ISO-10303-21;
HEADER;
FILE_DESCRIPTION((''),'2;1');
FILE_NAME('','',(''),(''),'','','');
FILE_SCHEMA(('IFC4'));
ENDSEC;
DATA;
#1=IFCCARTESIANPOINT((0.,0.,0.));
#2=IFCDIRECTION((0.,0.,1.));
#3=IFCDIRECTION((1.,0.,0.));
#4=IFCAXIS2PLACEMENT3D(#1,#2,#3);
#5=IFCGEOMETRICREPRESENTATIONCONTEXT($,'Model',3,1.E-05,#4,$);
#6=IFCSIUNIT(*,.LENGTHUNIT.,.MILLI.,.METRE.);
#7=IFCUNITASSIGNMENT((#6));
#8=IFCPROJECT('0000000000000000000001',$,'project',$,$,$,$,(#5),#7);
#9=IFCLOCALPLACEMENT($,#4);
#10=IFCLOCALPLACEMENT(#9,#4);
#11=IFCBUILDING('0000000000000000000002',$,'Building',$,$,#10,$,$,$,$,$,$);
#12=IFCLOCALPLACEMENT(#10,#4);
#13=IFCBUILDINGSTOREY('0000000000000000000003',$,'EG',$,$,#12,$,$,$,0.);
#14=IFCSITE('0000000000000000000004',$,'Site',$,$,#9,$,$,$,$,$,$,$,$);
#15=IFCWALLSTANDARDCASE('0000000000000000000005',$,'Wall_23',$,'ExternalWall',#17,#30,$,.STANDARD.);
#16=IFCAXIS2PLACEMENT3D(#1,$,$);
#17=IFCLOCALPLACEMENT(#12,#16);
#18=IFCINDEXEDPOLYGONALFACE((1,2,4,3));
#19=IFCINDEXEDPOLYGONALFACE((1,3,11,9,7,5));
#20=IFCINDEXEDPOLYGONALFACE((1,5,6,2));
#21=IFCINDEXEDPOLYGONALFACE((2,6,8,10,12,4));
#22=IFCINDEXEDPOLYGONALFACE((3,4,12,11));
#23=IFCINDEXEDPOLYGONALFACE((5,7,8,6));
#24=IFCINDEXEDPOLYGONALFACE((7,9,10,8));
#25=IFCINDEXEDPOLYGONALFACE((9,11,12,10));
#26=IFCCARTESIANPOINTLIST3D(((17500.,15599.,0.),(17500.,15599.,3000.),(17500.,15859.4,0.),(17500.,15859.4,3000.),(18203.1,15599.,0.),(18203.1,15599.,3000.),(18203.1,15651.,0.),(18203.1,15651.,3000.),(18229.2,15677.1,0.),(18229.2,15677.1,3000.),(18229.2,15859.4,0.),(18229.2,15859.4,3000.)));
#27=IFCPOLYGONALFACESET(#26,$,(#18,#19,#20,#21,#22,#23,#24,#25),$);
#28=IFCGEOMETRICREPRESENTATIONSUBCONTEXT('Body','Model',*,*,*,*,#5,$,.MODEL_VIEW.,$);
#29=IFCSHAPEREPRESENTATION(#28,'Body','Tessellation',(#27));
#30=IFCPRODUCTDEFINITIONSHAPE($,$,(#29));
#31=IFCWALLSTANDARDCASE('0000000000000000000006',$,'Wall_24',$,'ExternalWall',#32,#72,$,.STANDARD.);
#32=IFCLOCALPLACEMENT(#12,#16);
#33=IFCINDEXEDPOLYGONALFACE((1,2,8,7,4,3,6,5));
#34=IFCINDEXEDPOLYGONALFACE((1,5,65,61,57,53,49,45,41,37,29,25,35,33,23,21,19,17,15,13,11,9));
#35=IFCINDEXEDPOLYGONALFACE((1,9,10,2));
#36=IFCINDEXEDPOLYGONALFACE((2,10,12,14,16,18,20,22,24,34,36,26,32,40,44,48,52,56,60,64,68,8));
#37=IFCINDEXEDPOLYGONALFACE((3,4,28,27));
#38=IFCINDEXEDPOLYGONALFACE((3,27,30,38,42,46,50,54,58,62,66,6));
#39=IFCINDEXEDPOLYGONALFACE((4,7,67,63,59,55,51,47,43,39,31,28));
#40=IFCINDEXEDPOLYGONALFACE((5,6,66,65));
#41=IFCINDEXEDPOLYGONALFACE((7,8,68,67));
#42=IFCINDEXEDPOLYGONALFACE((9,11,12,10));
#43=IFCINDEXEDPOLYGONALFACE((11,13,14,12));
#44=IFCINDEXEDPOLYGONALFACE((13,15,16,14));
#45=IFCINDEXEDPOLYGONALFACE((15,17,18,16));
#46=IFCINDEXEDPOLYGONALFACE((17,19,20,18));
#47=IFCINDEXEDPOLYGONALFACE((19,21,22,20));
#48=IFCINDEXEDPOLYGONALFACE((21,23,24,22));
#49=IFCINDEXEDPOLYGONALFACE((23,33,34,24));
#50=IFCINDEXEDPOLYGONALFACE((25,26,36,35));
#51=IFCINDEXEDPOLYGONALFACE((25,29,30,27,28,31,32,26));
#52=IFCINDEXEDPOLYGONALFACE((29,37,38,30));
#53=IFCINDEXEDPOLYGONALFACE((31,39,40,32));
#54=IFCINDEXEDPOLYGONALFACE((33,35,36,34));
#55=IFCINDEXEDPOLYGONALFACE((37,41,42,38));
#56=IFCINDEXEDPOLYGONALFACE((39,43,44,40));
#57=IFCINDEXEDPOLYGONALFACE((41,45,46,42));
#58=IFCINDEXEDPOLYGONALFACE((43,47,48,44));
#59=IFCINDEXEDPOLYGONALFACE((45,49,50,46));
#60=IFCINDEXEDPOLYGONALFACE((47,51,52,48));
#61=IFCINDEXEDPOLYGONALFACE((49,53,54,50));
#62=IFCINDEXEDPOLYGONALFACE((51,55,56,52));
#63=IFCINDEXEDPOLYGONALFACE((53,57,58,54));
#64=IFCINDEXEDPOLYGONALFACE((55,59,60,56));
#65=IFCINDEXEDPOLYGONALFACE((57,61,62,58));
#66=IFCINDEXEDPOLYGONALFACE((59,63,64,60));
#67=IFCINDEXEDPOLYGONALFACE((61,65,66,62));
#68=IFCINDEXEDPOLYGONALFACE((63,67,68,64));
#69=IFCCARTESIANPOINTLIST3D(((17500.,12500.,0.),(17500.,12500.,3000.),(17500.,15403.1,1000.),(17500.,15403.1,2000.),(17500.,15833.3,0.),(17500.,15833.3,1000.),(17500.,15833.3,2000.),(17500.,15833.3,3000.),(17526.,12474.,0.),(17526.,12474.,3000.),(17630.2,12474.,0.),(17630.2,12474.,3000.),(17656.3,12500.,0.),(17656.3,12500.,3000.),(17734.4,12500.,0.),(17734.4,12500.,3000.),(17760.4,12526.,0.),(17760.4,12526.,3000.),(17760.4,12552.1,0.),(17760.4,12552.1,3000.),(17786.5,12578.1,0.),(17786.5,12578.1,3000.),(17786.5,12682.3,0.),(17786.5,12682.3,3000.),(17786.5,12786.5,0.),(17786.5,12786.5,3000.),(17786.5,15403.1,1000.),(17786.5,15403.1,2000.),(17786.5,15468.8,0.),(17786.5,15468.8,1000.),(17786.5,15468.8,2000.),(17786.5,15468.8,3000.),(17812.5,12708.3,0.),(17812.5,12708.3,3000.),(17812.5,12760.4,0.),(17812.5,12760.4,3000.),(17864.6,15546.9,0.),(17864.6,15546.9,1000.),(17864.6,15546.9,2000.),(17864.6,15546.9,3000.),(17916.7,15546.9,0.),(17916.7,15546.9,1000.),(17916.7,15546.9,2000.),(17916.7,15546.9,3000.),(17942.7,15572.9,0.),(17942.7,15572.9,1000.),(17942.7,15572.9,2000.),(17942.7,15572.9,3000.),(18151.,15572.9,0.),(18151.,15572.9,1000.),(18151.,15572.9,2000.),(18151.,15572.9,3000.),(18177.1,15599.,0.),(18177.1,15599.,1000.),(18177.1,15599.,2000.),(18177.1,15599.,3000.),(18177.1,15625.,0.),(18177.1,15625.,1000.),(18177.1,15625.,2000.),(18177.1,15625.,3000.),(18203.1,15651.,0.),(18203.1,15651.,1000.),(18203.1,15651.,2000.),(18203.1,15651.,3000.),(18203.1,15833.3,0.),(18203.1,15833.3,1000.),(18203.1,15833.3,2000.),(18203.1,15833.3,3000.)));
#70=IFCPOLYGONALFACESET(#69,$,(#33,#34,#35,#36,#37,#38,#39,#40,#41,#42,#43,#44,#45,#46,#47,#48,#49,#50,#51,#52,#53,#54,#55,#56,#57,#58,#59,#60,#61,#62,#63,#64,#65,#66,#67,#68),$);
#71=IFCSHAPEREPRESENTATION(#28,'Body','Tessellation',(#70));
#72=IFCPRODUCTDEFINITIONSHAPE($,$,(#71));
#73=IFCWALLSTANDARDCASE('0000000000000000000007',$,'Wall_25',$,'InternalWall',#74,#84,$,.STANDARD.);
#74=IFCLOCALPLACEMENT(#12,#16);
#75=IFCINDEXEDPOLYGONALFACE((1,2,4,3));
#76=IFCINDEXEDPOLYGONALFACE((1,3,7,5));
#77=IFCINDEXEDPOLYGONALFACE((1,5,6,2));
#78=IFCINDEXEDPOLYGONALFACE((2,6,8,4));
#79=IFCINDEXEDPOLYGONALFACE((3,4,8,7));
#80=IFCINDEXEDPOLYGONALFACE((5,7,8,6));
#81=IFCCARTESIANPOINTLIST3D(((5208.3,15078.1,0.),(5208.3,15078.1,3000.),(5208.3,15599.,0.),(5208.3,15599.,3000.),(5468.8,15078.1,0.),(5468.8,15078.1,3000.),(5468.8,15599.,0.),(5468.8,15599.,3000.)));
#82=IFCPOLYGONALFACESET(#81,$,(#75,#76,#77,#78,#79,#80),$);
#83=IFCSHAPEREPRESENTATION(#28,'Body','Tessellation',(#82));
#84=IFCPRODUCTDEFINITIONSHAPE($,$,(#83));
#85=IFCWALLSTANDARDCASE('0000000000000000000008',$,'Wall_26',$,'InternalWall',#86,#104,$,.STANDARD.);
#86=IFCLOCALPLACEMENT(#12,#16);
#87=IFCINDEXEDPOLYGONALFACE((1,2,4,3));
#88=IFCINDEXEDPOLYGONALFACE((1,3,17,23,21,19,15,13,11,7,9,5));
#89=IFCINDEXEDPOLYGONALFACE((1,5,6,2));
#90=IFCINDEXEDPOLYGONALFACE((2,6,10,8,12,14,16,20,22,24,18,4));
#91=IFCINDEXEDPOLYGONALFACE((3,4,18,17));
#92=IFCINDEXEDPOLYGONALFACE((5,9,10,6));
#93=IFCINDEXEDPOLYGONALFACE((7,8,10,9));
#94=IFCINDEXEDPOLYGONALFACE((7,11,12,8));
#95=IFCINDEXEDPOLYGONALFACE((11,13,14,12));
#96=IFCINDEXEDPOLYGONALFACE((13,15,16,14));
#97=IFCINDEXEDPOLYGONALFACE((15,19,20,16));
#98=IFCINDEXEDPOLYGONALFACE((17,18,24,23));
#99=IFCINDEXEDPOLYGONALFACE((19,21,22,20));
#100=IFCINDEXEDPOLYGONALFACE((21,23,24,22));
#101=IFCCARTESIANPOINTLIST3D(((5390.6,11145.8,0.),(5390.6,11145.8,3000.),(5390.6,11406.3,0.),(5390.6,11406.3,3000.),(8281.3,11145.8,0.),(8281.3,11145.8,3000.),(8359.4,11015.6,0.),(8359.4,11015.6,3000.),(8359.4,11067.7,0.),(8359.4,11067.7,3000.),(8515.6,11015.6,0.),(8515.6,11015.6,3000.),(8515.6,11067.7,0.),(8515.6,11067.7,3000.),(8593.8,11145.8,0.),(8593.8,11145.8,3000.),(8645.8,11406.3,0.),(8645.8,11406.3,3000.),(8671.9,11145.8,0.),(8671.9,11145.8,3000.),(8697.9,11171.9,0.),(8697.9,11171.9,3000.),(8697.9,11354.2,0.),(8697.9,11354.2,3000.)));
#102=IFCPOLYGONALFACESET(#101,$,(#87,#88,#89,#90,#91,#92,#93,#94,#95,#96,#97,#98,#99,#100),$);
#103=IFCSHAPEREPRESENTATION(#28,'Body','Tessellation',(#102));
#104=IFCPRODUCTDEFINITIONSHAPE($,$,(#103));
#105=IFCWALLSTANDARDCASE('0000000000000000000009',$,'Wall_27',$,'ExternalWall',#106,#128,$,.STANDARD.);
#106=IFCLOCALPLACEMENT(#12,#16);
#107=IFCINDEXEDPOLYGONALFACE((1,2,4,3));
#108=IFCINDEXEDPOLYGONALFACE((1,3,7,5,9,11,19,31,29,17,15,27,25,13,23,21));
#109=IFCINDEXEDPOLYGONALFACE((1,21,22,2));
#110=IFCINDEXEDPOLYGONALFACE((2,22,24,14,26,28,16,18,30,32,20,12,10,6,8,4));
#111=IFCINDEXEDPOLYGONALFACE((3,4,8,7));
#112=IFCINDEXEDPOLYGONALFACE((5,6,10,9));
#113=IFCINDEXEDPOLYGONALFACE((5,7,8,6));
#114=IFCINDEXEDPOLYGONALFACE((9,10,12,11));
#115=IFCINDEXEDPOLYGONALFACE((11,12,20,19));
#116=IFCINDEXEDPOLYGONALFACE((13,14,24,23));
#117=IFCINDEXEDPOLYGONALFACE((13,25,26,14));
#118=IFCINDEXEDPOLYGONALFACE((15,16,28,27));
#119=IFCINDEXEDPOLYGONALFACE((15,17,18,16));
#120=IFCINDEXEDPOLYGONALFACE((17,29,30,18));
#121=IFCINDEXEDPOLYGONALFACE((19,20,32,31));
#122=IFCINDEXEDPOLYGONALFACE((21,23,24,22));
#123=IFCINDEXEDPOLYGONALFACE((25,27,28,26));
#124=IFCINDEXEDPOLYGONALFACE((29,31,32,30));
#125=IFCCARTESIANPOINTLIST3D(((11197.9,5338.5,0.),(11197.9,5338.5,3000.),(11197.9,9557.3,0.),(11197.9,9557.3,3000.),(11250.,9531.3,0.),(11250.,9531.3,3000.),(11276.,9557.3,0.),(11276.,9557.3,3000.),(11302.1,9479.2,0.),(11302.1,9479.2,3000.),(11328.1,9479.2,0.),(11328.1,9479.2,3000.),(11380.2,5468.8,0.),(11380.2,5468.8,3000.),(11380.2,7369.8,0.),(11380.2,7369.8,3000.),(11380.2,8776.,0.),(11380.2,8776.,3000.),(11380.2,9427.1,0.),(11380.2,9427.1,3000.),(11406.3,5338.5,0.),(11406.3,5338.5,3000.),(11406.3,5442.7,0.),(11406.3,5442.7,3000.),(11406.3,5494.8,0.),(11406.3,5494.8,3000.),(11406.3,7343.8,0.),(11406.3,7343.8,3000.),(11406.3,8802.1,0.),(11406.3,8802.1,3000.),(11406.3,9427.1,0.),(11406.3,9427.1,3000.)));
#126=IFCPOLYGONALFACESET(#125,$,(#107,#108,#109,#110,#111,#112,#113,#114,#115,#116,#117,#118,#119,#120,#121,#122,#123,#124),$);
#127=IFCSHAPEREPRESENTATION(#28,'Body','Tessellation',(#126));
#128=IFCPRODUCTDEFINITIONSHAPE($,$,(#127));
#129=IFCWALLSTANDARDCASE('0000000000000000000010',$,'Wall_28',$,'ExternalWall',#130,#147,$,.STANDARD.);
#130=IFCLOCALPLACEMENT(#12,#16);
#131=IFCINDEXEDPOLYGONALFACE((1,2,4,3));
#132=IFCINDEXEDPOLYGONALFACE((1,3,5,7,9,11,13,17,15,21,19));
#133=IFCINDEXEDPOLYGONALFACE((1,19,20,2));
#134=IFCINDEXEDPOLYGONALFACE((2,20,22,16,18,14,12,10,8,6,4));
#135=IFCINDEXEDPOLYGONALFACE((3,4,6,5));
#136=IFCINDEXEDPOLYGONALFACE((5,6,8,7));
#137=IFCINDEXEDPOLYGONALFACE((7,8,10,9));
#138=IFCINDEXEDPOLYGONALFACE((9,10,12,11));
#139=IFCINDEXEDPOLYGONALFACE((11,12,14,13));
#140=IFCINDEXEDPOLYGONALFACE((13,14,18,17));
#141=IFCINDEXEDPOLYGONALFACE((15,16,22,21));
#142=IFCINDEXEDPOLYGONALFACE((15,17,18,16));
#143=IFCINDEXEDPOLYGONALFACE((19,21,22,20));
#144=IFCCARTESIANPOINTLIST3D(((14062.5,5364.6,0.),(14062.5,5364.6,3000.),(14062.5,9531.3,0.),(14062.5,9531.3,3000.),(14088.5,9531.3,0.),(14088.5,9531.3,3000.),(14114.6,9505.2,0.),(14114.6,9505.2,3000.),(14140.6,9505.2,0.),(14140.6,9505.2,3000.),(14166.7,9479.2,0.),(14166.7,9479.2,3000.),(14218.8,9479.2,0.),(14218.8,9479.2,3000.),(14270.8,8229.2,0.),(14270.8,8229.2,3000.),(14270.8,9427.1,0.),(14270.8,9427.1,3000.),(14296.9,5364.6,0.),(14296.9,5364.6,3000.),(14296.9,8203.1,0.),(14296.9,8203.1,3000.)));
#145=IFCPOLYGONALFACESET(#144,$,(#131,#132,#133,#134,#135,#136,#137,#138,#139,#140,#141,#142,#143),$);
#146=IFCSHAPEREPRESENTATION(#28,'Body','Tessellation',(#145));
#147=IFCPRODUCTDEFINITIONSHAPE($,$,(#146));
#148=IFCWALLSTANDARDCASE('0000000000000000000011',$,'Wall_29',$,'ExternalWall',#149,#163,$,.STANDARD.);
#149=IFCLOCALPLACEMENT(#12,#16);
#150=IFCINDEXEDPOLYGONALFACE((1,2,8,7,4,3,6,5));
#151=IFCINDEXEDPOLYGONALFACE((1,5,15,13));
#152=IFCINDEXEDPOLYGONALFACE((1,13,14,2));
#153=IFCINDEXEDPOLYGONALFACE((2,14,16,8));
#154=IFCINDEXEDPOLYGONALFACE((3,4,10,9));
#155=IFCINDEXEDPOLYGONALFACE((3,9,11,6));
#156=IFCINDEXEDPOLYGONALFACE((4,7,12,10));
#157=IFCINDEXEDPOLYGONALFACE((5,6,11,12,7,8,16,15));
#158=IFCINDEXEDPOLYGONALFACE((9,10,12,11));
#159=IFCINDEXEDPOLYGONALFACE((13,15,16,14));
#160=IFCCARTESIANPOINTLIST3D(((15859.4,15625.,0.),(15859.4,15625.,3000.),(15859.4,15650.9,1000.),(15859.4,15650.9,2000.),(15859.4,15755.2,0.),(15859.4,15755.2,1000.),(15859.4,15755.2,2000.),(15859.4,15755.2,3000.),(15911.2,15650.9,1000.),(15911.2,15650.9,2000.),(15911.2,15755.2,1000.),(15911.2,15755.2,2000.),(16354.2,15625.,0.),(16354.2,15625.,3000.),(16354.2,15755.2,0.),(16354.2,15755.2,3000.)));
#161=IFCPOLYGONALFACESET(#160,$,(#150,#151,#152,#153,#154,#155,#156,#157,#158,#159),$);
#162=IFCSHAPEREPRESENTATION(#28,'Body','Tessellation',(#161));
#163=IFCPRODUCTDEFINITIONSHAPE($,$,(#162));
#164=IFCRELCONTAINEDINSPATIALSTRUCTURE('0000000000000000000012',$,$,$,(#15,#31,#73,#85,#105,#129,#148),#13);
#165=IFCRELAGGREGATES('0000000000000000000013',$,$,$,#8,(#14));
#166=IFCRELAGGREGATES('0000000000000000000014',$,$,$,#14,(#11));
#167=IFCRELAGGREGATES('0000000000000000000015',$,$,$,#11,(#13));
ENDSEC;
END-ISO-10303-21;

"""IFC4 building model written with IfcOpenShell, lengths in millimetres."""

from ifc_helpers import new_model, si_unit, frame, origin_with_axes, place, context, subcontext, project, spatial, polyline, rectangle, outline, extrude, element, save


model = new_model("IFC4")

# Units and contexts
model_context = context("Model", 3, precision=1e-05, world=origin_with_axes())
body_context = subcontext(model_context, "Body", "Model", "MODEL_VIEW")
ifc_project = project(units=[si_unit("LENGTHUNIT", "METRE", prefix="MILLI")], contexts=[model_context])

# Site, building, storey
site_placement = place(None, origin_with_axes())
site = spatial("IfcSite", under=ifc_project, at=site_placement, Name="Site")
building_placement = place(site_placement, origin_with_axes())
building = spatial("IfcBuilding", under=site, at=building_placement, Name="Building")
storey_placement = place(building_placement, origin_with_axes())
storey = spatial("IfcBuildingStorey", under=building, at=storey_placement, Name="EG", Elevation=0.0)

# Wall
wall_1_placement = place(storey_placement, origin_with_axes())
element("IfcWallStandardCase", 1, at=wall_1_placement, inside=storey, Name="Wall_23", ObjectType="ExternalWall", PredefinedType="STANDARD", context=body_context, shape_type="SweptSolid", body=[
    extrude(outline(polyline([(17500.0, 15599.0, 0.0), (17500.0, 15859.4, 0.0), (18229.2, 15859.4, 0.0), (18229.2, 15677.1, 0.0), (18203.1, 15651.0, 0.0), (18203.1, 15599.0, 0.0), (17500.0, 15599.0, 0.0)])), origin_with_axes(), (0.0, 0.0, 1.0), 3000.0),
])

# Wall, opening
wall_2_placement = place(storey_placement, origin_with_axes())
wall_2 = element("IfcWallStandardCase", 2, at=wall_2_placement, inside=storey, Name="Wall_24", ObjectType="ExternalWall", PredefinedType="STANDARD", context=body_context, shape_type="SweptSolid", body=[
    extrude(outline(polyline([(17526.0, 12474.0, 0.0), (17500.0, 12500.0, 0.0), (17500.0, 15833.3, 0.0), (18203.1, 15833.3, 0.0), (18203.1, 15651.0, 0.0), (18177.1, 15625.0, 0.0), (18177.1, 15599.0, 0.0), (18151.0, 15572.9, 0.0), (17942.7, 15572.9, 0.0), (17916.7, 15546.9, 0.0), (17864.6, 15546.9, 0.0), (17786.5, 15468.8, 0.0), (17786.5, 12786.5, 0.0), (17812.5, 12760.4, 0.0), (17812.5, 12708.3, 0.0), (17786.5, 12682.3, 0.0), (17786.5, 12578.1, 0.0), (17760.4, 12552.1, 0.0), (17760.4, 12526.0, 0.0), (17734.4, 12500.0, 0.0), (17656.3, 12500.0, 0.0), (17630.2, 12474.0, 0.0), (17526.0, 12474.0, 0.0)])), origin_with_axes(), (0.0, 0.0, 1.0), 3000.0),
])
opening_1_placement = place(wall_2_placement, origin_with_axes())
element("IfcOpeningElement", 3, at=opening_1_placement, inside=storey, cuts=wall_2, context=body_context, shape_type="SweptSolid", body=[
    extrude(rectangle(XDim=600.0, YDim=703.1), frame((17851.6, 15703.1, 1000.0), z_axis=(0.0, 0.0, 1.0), x_axis=(0.0, 1.0, 0.0)), (0.0, 0.0, 1.0), 1000.0),
])

# Walls
wall_3_placement = place(storey_placement, origin_with_axes())
element("IfcWallStandardCase", 4, at=wall_3_placement, inside=storey, Name="Wall_25", ObjectType="InternalWall", PredefinedType="STANDARD", context=body_context, shape_type="SweptSolid", body=[
    extrude(outline(polyline([(5208.3, 15078.1, 0.0), (5208.3, 15599.0, 0.0), (5468.8, 15599.0, 0.0), (5468.8, 15078.1, 0.0), (5208.3, 15078.1, 0.0)])), origin_with_axes(), (0.0, 0.0, 1.0), 3000.0),
])
wall_4_placement = place(storey_placement, origin_with_axes())
element("IfcWallStandardCase", 5, at=wall_4_placement, inside=storey, Name="Wall_26", ObjectType="InternalWall", PredefinedType="STANDARD", context=body_context, shape_type="SweptSolid", body=[
    extrude(outline(polyline([(8359.4, 11015.6, 0.0), (8359.4, 11067.7, 0.0), (8281.3, 11145.8, 0.0), (5390.6, 11145.8, 0.0), (5390.6, 11406.3, 0.0), (8645.8, 11406.3, 0.0), (8697.9, 11354.2, 0.0), (8697.9, 11171.9, 0.0), (8671.9, 11145.8, 0.0), (8593.8, 11145.8, 0.0), (8515.6, 11067.7, 0.0), (8515.6, 11015.6, 0.0), (8359.4, 11015.6, 0.0)])), origin_with_axes(), (0.0, 0.0, 1.0), 3000.0),
])
wall_5_placement = place(storey_placement, origin_with_axes())
element("IfcWallStandardCase", 6, at=wall_5_placement, inside=storey, Name="Wall_27", ObjectType="ExternalWall", PredefinedType="STANDARD", context=body_context, shape_type="SweptSolid", body=[
    extrude(outline(polyline([(11197.9, 5338.5, 0.0), (11197.9, 9557.3, 0.0), (11276.0, 9557.3, 0.0), (11250.0, 9531.3, 0.0), (11302.1, 9479.2, 0.0), (11328.1, 9479.2, 0.0), (11380.2, 9427.1, 0.0), (11406.3, 9427.1, 0.0), (11406.3, 8802.1, 0.0), (11380.2, 8776.0, 0.0), (11380.2, 7369.8, 0.0), (11406.3, 7343.8, 0.0), (11406.3, 5494.8, 0.0), (11380.2, 5468.8, 0.0), (11406.3, 5442.7, 0.0), (11406.3, 5338.5, 0.0), (11197.9, 5338.5, 0.0)])), origin_with_axes(), (0.0, 0.0, 1.0), 3000.0),
])
wall_6_placement = place(storey_placement, origin_with_axes())
element("IfcWallStandardCase", 7, at=wall_6_placement, inside=storey, Name="Wall_28", ObjectType="ExternalWall", PredefinedType="STANDARD", context=body_context, shape_type="SweptSolid", body=[
    extrude(outline(polyline([(14062.5, 5364.6, 0.0), (14062.5, 9531.3, 0.0), (14088.5, 9531.3, 0.0), (14114.6, 9505.2, 0.0), (14140.6, 9505.2, 0.0), (14166.7, 9479.2, 0.0), (14218.8, 9479.2, 0.0), (14270.8, 9427.1, 0.0), (14270.8, 8229.2, 0.0), (14296.9, 8203.1, 0.0), (14296.9, 5364.6, 0.0), (14062.5, 5364.6, 0.0)])), origin_with_axes(), (0.0, 0.0, 1.0), 3000.0),
])

# Wall, opening
wall_7_placement = place(storey_placement, origin_with_axes())
wall_7 = element("IfcWallStandardCase", 8, at=wall_7_placement, inside=storey, Name="Wall_29", ObjectType="ExternalWall", PredefinedType="STANDARD", context=body_context, shape_type="SweptSolid", body=[
    extrude(outline(polyline([(15859.4, 15625.0, 0.0), (15859.4, 15755.2, 0.0), (16354.2, 15755.2, 0.0), (16354.2, 15625.0, 0.0), (15859.4, 15625.0, 0.0)])), origin_with_axes(), (0.0, 0.0, 1.0), 3000.0),
])
opening_2_placement = place(wall_7_placement, origin_with_axes())
element("IfcOpeningElement", 9, at=opening_2_placement, inside=storey, cuts=wall_7, context=body_context, shape_type="SweptSolid", body=[
    extrude(rectangle(XDim=1200.0, YDim=130.2), frame((15311.2, 15716.0, 1000.0), z_axis=(0.0, 0.0, 1.0), x_axis=(1.0, 0.0, 0.0)), (0.0, 0.0, 1.0), 1000.0),
])

save(model, "model.ifc")
